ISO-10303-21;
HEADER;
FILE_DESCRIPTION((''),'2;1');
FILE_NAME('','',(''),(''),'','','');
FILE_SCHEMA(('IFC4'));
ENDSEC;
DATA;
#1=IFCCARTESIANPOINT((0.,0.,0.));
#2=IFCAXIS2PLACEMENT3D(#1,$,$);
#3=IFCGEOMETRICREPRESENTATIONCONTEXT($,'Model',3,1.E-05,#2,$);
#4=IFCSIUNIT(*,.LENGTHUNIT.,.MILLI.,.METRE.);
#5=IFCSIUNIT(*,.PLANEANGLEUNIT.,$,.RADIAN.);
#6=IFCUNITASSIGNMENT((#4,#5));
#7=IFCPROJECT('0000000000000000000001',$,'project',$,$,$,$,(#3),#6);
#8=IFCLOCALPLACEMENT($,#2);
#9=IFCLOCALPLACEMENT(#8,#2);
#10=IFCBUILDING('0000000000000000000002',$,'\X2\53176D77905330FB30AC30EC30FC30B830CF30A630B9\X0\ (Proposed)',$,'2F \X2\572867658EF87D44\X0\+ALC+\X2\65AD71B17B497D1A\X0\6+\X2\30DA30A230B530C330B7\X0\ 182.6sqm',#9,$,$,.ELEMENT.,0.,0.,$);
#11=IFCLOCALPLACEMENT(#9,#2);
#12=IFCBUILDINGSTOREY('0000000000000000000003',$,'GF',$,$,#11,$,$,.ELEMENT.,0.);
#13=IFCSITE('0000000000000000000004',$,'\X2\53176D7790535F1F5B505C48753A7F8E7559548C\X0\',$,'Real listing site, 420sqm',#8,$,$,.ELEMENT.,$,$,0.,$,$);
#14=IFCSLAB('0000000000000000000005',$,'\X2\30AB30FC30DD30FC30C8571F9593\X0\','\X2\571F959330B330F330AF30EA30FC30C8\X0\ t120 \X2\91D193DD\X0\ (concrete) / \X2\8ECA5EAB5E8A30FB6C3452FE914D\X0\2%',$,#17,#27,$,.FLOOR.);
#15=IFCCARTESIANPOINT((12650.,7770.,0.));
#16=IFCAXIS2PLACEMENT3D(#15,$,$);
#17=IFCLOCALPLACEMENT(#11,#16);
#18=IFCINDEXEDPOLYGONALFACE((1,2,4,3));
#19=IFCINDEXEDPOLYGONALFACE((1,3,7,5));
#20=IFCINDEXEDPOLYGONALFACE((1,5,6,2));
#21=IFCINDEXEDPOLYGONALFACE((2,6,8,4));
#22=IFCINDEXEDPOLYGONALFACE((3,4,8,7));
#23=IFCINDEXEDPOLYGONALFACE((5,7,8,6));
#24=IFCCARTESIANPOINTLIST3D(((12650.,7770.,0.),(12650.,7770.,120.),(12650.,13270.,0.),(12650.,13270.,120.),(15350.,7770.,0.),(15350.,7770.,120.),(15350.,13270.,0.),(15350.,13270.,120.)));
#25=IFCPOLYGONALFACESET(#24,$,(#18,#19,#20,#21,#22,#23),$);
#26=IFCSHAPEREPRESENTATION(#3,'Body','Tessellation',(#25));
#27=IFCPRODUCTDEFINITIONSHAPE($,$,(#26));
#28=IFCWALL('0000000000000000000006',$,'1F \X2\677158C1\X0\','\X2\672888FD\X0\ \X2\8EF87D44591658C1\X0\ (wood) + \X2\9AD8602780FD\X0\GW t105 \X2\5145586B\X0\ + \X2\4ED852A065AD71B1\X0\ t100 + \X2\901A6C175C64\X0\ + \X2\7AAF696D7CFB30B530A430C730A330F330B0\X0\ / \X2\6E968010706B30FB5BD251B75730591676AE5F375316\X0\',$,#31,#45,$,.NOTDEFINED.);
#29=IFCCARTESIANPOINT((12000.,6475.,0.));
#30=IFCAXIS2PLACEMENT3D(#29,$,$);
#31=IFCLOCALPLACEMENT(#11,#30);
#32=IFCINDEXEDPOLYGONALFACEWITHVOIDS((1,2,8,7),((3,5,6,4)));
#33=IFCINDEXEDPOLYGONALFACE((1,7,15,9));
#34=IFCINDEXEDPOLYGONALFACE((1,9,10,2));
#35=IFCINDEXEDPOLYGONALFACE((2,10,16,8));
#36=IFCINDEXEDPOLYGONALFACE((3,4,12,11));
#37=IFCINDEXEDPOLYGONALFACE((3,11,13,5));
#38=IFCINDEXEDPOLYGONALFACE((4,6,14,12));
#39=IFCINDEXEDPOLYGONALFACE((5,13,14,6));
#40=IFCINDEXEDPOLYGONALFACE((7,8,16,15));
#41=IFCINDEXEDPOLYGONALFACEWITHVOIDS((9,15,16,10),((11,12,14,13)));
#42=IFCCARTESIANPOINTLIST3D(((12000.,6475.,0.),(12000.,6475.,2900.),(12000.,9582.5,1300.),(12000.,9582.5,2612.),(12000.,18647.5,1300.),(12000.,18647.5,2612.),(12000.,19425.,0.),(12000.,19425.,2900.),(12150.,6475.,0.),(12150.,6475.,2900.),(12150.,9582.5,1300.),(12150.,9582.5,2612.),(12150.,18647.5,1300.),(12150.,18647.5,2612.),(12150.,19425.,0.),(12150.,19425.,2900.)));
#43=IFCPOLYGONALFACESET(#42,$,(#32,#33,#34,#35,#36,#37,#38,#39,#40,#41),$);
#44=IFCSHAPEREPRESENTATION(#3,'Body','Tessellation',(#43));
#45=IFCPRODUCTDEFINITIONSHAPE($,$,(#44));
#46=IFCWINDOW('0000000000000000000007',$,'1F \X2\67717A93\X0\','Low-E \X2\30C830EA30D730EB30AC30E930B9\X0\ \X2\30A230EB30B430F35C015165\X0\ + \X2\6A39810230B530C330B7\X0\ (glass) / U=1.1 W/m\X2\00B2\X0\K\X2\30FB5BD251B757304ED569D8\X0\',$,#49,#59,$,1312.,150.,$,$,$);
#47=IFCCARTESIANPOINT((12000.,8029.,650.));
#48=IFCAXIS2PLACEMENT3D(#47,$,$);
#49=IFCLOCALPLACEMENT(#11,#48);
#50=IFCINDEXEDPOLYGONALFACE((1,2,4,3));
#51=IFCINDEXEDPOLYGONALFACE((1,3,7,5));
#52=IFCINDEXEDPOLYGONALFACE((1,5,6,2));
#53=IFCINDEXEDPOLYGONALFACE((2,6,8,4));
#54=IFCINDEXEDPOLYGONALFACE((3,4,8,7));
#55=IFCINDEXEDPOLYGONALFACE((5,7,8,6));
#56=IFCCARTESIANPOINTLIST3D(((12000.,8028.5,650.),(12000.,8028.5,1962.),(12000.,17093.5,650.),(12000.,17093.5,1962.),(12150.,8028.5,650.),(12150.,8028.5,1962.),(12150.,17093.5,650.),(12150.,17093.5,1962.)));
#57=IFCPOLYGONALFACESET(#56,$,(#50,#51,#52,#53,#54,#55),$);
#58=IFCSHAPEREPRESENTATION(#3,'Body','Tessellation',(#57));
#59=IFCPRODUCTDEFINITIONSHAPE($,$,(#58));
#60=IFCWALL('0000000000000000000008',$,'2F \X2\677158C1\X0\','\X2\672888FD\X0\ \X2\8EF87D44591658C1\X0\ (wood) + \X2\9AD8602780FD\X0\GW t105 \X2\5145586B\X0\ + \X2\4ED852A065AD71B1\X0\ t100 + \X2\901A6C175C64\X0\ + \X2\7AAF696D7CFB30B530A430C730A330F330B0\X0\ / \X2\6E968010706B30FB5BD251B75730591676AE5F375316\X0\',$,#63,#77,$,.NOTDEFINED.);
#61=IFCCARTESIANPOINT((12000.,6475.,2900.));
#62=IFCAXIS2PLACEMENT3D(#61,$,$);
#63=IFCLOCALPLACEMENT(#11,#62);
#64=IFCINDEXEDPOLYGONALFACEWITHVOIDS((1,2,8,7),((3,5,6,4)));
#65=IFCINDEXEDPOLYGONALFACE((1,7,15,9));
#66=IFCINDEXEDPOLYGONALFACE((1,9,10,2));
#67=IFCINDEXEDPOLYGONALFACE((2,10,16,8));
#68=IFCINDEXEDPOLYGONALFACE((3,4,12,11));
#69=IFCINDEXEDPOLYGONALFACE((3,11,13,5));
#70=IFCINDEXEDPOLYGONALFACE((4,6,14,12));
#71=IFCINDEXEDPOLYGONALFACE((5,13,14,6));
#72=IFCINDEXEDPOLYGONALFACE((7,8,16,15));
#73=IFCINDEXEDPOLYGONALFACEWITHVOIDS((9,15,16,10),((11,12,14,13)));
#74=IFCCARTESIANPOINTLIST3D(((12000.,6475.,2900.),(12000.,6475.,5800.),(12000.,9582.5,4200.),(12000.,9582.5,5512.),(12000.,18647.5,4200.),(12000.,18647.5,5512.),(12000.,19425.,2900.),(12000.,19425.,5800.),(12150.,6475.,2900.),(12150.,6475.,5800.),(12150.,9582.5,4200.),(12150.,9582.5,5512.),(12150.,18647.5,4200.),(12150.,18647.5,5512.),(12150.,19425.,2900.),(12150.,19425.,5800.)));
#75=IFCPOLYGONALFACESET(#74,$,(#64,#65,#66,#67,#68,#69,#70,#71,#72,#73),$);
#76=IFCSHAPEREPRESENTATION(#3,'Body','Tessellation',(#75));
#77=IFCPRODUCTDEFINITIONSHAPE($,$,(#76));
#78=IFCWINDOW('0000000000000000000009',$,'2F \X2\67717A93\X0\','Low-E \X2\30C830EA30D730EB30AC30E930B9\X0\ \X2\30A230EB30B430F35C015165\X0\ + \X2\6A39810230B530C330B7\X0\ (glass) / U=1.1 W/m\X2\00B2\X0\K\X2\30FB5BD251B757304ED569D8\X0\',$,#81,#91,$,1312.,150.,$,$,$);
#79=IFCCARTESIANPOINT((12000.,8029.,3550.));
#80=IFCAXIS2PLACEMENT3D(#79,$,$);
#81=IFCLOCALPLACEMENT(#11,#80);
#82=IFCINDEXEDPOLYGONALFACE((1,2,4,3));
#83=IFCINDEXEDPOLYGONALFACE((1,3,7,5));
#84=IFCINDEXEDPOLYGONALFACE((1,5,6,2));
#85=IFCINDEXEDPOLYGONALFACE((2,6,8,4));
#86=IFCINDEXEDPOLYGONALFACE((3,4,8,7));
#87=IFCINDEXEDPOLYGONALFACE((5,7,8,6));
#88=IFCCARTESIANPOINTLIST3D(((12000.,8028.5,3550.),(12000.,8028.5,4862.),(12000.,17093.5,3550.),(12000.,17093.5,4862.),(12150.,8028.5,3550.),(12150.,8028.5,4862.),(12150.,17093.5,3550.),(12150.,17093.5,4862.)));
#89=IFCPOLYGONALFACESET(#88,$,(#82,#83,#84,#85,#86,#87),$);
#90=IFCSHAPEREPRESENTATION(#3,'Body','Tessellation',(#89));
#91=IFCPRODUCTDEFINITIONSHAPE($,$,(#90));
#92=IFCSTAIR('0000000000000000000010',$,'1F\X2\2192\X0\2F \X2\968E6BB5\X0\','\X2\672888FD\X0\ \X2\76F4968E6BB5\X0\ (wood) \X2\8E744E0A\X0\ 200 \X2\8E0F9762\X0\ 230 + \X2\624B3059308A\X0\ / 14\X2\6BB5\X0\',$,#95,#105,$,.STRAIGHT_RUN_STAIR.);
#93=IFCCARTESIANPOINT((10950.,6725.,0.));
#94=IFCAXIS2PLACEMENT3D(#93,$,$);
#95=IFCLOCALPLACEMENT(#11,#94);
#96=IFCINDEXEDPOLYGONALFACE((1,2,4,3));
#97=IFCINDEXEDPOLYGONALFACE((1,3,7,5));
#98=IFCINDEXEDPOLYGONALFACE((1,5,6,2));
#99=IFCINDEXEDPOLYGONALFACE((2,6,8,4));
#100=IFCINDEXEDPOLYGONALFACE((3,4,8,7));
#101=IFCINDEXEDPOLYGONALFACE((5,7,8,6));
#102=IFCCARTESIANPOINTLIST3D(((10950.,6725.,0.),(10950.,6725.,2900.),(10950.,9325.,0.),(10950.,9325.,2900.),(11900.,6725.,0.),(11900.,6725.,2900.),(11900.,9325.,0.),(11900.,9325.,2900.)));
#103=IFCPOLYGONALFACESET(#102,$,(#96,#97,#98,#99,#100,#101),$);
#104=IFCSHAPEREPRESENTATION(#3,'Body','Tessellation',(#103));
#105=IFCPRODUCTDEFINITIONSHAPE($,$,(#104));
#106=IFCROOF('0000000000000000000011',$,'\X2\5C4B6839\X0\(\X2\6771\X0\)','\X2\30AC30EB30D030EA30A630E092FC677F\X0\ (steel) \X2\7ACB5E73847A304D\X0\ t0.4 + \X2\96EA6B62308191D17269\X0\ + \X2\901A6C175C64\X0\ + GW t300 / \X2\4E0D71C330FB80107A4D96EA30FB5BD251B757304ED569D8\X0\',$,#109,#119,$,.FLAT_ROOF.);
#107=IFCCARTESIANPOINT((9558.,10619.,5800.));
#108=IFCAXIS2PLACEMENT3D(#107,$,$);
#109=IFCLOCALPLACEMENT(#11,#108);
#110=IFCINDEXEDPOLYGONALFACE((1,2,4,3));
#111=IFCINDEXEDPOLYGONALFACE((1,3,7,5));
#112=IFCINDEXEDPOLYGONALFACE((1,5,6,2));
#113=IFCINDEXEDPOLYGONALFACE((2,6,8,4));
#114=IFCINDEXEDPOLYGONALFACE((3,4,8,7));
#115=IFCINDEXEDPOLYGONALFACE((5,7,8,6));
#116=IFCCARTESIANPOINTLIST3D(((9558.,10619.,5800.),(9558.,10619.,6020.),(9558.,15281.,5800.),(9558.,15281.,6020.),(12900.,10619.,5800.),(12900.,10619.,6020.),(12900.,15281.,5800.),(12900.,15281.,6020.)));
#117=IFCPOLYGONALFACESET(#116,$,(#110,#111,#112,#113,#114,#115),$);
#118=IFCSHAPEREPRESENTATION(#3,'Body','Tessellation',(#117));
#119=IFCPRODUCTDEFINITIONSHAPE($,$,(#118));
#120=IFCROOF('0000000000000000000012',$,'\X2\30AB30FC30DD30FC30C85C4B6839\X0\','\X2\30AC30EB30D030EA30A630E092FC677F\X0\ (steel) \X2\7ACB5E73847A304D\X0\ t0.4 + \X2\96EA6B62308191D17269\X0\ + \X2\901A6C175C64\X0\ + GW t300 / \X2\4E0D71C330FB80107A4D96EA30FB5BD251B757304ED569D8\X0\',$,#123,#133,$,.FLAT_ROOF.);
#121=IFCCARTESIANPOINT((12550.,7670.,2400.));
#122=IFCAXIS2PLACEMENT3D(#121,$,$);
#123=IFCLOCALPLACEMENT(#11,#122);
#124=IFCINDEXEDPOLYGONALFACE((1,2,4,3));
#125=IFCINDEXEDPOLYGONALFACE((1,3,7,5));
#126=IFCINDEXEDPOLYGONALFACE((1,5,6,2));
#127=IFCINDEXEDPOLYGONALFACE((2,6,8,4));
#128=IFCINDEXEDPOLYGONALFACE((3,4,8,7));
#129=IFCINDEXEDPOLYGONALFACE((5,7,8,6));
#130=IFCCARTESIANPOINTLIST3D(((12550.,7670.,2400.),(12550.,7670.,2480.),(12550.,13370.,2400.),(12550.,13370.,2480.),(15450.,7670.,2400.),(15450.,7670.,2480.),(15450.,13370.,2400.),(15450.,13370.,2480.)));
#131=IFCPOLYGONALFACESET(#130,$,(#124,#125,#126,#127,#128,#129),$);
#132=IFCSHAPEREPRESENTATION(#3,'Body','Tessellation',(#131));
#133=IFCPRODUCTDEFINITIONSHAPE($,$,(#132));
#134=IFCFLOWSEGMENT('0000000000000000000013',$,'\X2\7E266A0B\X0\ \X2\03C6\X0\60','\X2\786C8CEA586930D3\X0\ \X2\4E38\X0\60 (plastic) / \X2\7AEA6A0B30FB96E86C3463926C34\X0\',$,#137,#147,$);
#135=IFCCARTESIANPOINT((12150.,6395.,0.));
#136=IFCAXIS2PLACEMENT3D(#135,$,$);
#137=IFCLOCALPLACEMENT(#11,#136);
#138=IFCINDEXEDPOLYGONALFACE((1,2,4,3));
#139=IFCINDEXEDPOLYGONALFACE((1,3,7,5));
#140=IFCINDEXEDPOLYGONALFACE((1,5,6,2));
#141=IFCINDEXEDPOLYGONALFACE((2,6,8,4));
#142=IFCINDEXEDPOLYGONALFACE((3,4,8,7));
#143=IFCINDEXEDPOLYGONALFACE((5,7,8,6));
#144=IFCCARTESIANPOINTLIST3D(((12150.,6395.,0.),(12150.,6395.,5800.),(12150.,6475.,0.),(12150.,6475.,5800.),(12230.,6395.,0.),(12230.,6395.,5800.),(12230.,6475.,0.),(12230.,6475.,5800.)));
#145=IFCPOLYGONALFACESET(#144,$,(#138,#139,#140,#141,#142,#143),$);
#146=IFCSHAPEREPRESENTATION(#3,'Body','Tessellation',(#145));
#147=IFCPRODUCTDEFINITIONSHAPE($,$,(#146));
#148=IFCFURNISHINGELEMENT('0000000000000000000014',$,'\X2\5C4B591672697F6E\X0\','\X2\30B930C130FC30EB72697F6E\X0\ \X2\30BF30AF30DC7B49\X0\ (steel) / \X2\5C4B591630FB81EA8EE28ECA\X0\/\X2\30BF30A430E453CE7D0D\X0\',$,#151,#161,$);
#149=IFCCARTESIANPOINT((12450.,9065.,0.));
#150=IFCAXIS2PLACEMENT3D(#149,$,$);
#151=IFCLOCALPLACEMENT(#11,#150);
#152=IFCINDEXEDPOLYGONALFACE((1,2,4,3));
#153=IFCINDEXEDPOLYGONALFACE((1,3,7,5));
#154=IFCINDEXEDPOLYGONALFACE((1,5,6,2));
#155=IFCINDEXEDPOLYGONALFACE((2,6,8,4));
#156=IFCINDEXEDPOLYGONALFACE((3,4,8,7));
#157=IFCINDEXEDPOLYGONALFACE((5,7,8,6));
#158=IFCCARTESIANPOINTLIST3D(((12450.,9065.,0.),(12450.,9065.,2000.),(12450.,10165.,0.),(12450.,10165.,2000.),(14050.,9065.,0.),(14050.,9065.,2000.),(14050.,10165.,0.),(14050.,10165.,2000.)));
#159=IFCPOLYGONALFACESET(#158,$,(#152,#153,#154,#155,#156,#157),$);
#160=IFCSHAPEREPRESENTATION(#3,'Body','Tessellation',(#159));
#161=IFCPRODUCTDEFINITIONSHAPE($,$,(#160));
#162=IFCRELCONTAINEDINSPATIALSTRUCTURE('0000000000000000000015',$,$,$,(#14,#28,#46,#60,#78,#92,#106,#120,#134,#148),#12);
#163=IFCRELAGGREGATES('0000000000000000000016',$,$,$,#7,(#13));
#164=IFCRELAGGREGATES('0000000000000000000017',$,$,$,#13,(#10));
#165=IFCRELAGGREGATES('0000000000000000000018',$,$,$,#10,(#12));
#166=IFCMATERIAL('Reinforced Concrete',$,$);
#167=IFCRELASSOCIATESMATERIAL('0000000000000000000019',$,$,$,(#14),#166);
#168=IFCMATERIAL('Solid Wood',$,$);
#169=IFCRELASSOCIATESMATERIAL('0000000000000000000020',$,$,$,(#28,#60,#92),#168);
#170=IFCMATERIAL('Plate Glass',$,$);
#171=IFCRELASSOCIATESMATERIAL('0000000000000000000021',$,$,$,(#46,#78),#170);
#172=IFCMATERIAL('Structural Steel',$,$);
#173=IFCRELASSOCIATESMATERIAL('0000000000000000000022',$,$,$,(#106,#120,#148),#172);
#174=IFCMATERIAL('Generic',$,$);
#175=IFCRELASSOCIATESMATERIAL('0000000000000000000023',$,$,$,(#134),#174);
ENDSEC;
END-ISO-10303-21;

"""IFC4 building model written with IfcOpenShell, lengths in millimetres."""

from ifc_helpers import new_model, si_unit, frame, frame_2d, origin, place, context, project, spatial, rectangle, extrude, material, element, fill, save


model = new_model("IFC4")

# Units and contexts
model_context = context("Model", 3, precision=1e-05, world=origin())
ifc_project = project(units=[si_unit("LENGTHUNIT", "METRE", prefix="MILLI"), si_unit("PLANEANGLEUNIT", "RADIAN")], contexts=[model_context])

# Site, building, storey
site_placement = place(None, origin())
site = spatial("IfcSite", under=ifc_project, at=site_placement, Name="北海道弟子屈町美留和", ObjectType="Real listing site, 420sqm", CompositionType="ELEMENT", RefElevation=0.0)
building_placement = place(site_placement, origin())
building = spatial("IfcBuilding", under=site, at=building_placement, Name="北海道・ガレージハウス (Proposed)", ObjectType="2F 在来軸組+ALC+断熱等級6+ペアサッシ 182.6sqm", CompositionType="ELEMENT", ElevationOfRefHeight=0.0, ElevationOfTerrain=0.0)
storey_placement = place(building_placement, origin())
storey = spatial("IfcBuildingStorey", under=building, at=storey_placement, Name="GF", CompositionType="ELEMENT", Elevation=0.0)

# Shared definitions
ifc_material_1 = material(Name="Solid Wood")
ifc_material_2 = material(Name="Structural Steel")

# Slab
ifc_material_3 = material(Name="Reinforced Concrete")
slab_1_placement = place(storey_placement, frame((12650.0, 7770.0, 0.0)))
element("IfcSlab", 1, at=slab_1_placement, inside=storey, material=ifc_material_3, Name="カーポート土間", Description="土間コンクリート t120 金鏝 (concrete) / 車庫床・水勾配2%", PredefinedType="FLOOR", context=model_context, shape_type="SweptSolid", body=[
    extrude(rectangle(XDim=2700.0, YDim=5500.0, at=frame_2d((1350.0, 2750.0))), frame((12650.0, 7770.0, 0.0)), (0.0, 0.0, 1.0), 120.0),
])

# Walls, openings, windows
wall_1_placement = place(storey_placement, frame((12000.0, 6475.0, 0.0)))
wall_1 = element("IfcWall", 2, at=wall_1_placement, inside=storey, material=ifc_material_1, Name="1F 東壁", Description="木製 軸組外壁 (wood) + 高性能GW t105 充填 + 付加断熱 t100 + 通気層 + 窯業系サイディング / 準耐火・寒冷地外皮強化", PredefinedType="NOTDEFINED", context=model_context, shape_type="SweptSolid", body=[
    extrude(rectangle(XDim=150.0, YDim=12950.0, at=frame_2d((75.0, 6475.0))), frame((12000.0, 6475.0, 0.0)), (0.0, 0.0, 1.0), 2900.0),
])
opening_1_placement = place(storey_placement, frame((12000.0, 8029.0, 650.0)))
opening_1 = element("IfcOpeningElement", 3, at=opening_1_placement, cuts=wall_1, PredefinedType="NOTDEFINED", context=model_context, shape_type="SweptSolid", body=[
    extrude(rectangle(XDim=150.0, YDim=9065.0, at=frame_2d((75.0, 4532.0))), frame((12000.0, 8029.0, 650.0)), (0.0, 0.0, 1.0), 1312.0),
])
ifc_material_4 = material(Name="Plate Glass")
window_1_placement = place(storey_placement, frame((12000.0, 8029.0, 650.0)))
window_1 = element("IfcWindow", 4, at=window_1_placement, inside=storey, material=ifc_material_4, Name="1F 東窓", Description="Low-E トリプルガラス アルゴン封入 + 樹脂サッシ (glass) / U=1.1 W/m²K・寒冷地仕様", OverallHeight=1312.0, OverallWidth=150.0, context=model_context, shape_type="SweptSolid", body=[
    extrude(rectangle(XDim=150.0, YDim=9065.0, at=frame_2d((75.0, 4532.0))), frame((12000.0, 8029.0, 650.0)), (0.0, 0.0, 1.0), 1312.0),
])
fill(opening_1, window_1)
wall_2_placement = place(storey_placement, frame((12000.0, 6475.0, 2900.0)))
wall_2 = element("IfcWall", 5, at=wall_2_placement, inside=storey, material=ifc_material_1, Name="2F 東壁", Description="木製 軸組外壁 (wood) + 高性能GW t105 充填 + 付加断熱 t100 + 通気層 + 窯業系サイディング / 準耐火・寒冷地外皮強化", PredefinedType="NOTDEFINED", context=model_context, shape_type="SweptSolid", body=[
    extrude(rectangle(XDim=150.0, YDim=12950.0, at=frame_2d((75.0, 6475.0))), frame((12000.0, 6475.0, 2900.0)), (0.0, 0.0, 1.0), 2900.0),
])
opening_2_placement = place(storey_placement, frame((12000.0, 8029.0, 3550.0)))
opening_2 = element("IfcOpeningElement", 6, at=opening_2_placement, cuts=wall_2, PredefinedType="NOTDEFINED", context=model_context, shape_type="SweptSolid", body=[
    extrude(rectangle(XDim=150.0, YDim=9065.0, at=frame_2d((75.0, 4532.0))), frame((12000.0, 8029.0, 3550.0)), (0.0, 0.0, 1.0), 1312.0),
])
window_2_placement = place(storey_placement, frame((12000.0, 8029.0, 3550.0)))
window_2 = element("IfcWindow", 7, at=window_2_placement, inside=storey, material=ifc_material_4, Name="2F 東窓", Description="Low-E トリプルガラス アルゴン封入 + 樹脂サッシ (glass) / U=1.1 W/m²K・寒冷地仕様", OverallHeight=1312.0, OverallWidth=150.0, context=model_context, shape_type="SweptSolid", body=[
    extrude(rectangle(XDim=150.0, YDim=9065.0, at=frame_2d((75.0, 4532.0))), frame((12000.0, 8029.0, 3550.0)), (0.0, 0.0, 1.0), 1312.0),
])
fill(opening_2, window_2)

# Stair
stair_placement = place(storey_placement, frame((10950.0, 6725.0, 0.0)))
element("IfcStair", 8, at=stair_placement, inside=storey, material=ifc_material_1, Name="1F→2F 階段", Description="木製 直階段 (wood) 蹴上 200 踏面 230 + 手すり / 14段", PredefinedType="STRAIGHT_RUN_STAIR", context=model_context, shape_type="SweptSolid", body=[
    extrude(rectangle(XDim=950.0, YDim=2600.0, at=frame_2d((475.0, 1300.0))), frame((10950.0, 6725.0, 0.0)), (0.0, 0.0, 1.0), 2900.0),
])

# Roofs
roof_1_placement = place(storey_placement, frame((9558.0, 10619.0, 5800.0)))
element("IfcRoof", 9, at=roof_1_placement, inside=storey, material=ifc_material_2, Name="屋根(東)", Description="ガルバリウム鋼板 (steel) 立平葺き t0.4 + 雪止め金物 + 通気層 + GW t300 / 不燃・耐積雪・寒冷地仕様", PredefinedType="FLAT_ROOF", context=model_context, shape_type="SweptSolid", body=[
    extrude(rectangle(XDim=3342.0, YDim=4662.0, at=frame_2d((1671.0, 2331.0))), frame((9558.0, 10619.0, 5800.0)), (0.0, 0.0, 1.0), 220.0),
])
roof_2_placement = place(storey_placement, frame((12550.0, 7670.0, 2400.0)))
element("IfcRoof", 10, at=roof_2_placement, inside=storey, material=ifc_material_2, Name="カーポート屋根", Description="ガルバリウム鋼板 (steel) 立平葺き t0.4 + 雪止め金物 + 通気層 + GW t300 / 不燃・耐積雪・寒冷地仕様", PredefinedType="FLAT_ROOF", context=model_context, shape_type="SweptSolid", body=[
    extrude(rectangle(XDim=2900.0, YDim=5700.0, at=frame_2d((1450.0, 2850.0))), frame((12550.0, 7670.0, 2400.0)), (0.0, 0.0, 1.0), 80.0),
])

# Flow segment
ifc_material_5 = material(Name="Generic")
flow_segment_placement = place(storey_placement, frame((12150.0, 6395.0, 0.0)))
element("IfcFlowSegment", 11, at=flow_segment_placement, inside=storey, material=ifc_material_5, Name="縦樋 φ60", Description="硬質塩ビ 丸60 (plastic) / 竪樋・雨水排水", context=model_context, shape_type="SweptSolid", body=[
    extrude(rectangle(XDim=80.0, YDim=80.0, at=frame_2d((40.0, 40.0))), frame((12150.0, 6395.0, 0.0)), (0.0, 0.0, 1.0), 5800.0),
])

# Furnishing element
furnishing_placement = place(storey_placement, frame((12450.0, 9065.0, 0.0)))
element("IfcFurnishingElement", 12, at=furnishing_placement, inside=storey, material=ifc_material_2, Name="屋外物置", Description="スチール物置 タクボ等 (steel) / 屋外・自転車/タイヤ収納", context=model_context, shape_type="SweptSolid", body=[
    extrude(rectangle(XDim=1600.0, YDim=1100.0, at=frame_2d((800.0, 550.0))), frame((12450.0, 9065.0, 0.0)), (0.0, 0.0, 1.0), 2000.0),
])

save(model, "model.ifc")
